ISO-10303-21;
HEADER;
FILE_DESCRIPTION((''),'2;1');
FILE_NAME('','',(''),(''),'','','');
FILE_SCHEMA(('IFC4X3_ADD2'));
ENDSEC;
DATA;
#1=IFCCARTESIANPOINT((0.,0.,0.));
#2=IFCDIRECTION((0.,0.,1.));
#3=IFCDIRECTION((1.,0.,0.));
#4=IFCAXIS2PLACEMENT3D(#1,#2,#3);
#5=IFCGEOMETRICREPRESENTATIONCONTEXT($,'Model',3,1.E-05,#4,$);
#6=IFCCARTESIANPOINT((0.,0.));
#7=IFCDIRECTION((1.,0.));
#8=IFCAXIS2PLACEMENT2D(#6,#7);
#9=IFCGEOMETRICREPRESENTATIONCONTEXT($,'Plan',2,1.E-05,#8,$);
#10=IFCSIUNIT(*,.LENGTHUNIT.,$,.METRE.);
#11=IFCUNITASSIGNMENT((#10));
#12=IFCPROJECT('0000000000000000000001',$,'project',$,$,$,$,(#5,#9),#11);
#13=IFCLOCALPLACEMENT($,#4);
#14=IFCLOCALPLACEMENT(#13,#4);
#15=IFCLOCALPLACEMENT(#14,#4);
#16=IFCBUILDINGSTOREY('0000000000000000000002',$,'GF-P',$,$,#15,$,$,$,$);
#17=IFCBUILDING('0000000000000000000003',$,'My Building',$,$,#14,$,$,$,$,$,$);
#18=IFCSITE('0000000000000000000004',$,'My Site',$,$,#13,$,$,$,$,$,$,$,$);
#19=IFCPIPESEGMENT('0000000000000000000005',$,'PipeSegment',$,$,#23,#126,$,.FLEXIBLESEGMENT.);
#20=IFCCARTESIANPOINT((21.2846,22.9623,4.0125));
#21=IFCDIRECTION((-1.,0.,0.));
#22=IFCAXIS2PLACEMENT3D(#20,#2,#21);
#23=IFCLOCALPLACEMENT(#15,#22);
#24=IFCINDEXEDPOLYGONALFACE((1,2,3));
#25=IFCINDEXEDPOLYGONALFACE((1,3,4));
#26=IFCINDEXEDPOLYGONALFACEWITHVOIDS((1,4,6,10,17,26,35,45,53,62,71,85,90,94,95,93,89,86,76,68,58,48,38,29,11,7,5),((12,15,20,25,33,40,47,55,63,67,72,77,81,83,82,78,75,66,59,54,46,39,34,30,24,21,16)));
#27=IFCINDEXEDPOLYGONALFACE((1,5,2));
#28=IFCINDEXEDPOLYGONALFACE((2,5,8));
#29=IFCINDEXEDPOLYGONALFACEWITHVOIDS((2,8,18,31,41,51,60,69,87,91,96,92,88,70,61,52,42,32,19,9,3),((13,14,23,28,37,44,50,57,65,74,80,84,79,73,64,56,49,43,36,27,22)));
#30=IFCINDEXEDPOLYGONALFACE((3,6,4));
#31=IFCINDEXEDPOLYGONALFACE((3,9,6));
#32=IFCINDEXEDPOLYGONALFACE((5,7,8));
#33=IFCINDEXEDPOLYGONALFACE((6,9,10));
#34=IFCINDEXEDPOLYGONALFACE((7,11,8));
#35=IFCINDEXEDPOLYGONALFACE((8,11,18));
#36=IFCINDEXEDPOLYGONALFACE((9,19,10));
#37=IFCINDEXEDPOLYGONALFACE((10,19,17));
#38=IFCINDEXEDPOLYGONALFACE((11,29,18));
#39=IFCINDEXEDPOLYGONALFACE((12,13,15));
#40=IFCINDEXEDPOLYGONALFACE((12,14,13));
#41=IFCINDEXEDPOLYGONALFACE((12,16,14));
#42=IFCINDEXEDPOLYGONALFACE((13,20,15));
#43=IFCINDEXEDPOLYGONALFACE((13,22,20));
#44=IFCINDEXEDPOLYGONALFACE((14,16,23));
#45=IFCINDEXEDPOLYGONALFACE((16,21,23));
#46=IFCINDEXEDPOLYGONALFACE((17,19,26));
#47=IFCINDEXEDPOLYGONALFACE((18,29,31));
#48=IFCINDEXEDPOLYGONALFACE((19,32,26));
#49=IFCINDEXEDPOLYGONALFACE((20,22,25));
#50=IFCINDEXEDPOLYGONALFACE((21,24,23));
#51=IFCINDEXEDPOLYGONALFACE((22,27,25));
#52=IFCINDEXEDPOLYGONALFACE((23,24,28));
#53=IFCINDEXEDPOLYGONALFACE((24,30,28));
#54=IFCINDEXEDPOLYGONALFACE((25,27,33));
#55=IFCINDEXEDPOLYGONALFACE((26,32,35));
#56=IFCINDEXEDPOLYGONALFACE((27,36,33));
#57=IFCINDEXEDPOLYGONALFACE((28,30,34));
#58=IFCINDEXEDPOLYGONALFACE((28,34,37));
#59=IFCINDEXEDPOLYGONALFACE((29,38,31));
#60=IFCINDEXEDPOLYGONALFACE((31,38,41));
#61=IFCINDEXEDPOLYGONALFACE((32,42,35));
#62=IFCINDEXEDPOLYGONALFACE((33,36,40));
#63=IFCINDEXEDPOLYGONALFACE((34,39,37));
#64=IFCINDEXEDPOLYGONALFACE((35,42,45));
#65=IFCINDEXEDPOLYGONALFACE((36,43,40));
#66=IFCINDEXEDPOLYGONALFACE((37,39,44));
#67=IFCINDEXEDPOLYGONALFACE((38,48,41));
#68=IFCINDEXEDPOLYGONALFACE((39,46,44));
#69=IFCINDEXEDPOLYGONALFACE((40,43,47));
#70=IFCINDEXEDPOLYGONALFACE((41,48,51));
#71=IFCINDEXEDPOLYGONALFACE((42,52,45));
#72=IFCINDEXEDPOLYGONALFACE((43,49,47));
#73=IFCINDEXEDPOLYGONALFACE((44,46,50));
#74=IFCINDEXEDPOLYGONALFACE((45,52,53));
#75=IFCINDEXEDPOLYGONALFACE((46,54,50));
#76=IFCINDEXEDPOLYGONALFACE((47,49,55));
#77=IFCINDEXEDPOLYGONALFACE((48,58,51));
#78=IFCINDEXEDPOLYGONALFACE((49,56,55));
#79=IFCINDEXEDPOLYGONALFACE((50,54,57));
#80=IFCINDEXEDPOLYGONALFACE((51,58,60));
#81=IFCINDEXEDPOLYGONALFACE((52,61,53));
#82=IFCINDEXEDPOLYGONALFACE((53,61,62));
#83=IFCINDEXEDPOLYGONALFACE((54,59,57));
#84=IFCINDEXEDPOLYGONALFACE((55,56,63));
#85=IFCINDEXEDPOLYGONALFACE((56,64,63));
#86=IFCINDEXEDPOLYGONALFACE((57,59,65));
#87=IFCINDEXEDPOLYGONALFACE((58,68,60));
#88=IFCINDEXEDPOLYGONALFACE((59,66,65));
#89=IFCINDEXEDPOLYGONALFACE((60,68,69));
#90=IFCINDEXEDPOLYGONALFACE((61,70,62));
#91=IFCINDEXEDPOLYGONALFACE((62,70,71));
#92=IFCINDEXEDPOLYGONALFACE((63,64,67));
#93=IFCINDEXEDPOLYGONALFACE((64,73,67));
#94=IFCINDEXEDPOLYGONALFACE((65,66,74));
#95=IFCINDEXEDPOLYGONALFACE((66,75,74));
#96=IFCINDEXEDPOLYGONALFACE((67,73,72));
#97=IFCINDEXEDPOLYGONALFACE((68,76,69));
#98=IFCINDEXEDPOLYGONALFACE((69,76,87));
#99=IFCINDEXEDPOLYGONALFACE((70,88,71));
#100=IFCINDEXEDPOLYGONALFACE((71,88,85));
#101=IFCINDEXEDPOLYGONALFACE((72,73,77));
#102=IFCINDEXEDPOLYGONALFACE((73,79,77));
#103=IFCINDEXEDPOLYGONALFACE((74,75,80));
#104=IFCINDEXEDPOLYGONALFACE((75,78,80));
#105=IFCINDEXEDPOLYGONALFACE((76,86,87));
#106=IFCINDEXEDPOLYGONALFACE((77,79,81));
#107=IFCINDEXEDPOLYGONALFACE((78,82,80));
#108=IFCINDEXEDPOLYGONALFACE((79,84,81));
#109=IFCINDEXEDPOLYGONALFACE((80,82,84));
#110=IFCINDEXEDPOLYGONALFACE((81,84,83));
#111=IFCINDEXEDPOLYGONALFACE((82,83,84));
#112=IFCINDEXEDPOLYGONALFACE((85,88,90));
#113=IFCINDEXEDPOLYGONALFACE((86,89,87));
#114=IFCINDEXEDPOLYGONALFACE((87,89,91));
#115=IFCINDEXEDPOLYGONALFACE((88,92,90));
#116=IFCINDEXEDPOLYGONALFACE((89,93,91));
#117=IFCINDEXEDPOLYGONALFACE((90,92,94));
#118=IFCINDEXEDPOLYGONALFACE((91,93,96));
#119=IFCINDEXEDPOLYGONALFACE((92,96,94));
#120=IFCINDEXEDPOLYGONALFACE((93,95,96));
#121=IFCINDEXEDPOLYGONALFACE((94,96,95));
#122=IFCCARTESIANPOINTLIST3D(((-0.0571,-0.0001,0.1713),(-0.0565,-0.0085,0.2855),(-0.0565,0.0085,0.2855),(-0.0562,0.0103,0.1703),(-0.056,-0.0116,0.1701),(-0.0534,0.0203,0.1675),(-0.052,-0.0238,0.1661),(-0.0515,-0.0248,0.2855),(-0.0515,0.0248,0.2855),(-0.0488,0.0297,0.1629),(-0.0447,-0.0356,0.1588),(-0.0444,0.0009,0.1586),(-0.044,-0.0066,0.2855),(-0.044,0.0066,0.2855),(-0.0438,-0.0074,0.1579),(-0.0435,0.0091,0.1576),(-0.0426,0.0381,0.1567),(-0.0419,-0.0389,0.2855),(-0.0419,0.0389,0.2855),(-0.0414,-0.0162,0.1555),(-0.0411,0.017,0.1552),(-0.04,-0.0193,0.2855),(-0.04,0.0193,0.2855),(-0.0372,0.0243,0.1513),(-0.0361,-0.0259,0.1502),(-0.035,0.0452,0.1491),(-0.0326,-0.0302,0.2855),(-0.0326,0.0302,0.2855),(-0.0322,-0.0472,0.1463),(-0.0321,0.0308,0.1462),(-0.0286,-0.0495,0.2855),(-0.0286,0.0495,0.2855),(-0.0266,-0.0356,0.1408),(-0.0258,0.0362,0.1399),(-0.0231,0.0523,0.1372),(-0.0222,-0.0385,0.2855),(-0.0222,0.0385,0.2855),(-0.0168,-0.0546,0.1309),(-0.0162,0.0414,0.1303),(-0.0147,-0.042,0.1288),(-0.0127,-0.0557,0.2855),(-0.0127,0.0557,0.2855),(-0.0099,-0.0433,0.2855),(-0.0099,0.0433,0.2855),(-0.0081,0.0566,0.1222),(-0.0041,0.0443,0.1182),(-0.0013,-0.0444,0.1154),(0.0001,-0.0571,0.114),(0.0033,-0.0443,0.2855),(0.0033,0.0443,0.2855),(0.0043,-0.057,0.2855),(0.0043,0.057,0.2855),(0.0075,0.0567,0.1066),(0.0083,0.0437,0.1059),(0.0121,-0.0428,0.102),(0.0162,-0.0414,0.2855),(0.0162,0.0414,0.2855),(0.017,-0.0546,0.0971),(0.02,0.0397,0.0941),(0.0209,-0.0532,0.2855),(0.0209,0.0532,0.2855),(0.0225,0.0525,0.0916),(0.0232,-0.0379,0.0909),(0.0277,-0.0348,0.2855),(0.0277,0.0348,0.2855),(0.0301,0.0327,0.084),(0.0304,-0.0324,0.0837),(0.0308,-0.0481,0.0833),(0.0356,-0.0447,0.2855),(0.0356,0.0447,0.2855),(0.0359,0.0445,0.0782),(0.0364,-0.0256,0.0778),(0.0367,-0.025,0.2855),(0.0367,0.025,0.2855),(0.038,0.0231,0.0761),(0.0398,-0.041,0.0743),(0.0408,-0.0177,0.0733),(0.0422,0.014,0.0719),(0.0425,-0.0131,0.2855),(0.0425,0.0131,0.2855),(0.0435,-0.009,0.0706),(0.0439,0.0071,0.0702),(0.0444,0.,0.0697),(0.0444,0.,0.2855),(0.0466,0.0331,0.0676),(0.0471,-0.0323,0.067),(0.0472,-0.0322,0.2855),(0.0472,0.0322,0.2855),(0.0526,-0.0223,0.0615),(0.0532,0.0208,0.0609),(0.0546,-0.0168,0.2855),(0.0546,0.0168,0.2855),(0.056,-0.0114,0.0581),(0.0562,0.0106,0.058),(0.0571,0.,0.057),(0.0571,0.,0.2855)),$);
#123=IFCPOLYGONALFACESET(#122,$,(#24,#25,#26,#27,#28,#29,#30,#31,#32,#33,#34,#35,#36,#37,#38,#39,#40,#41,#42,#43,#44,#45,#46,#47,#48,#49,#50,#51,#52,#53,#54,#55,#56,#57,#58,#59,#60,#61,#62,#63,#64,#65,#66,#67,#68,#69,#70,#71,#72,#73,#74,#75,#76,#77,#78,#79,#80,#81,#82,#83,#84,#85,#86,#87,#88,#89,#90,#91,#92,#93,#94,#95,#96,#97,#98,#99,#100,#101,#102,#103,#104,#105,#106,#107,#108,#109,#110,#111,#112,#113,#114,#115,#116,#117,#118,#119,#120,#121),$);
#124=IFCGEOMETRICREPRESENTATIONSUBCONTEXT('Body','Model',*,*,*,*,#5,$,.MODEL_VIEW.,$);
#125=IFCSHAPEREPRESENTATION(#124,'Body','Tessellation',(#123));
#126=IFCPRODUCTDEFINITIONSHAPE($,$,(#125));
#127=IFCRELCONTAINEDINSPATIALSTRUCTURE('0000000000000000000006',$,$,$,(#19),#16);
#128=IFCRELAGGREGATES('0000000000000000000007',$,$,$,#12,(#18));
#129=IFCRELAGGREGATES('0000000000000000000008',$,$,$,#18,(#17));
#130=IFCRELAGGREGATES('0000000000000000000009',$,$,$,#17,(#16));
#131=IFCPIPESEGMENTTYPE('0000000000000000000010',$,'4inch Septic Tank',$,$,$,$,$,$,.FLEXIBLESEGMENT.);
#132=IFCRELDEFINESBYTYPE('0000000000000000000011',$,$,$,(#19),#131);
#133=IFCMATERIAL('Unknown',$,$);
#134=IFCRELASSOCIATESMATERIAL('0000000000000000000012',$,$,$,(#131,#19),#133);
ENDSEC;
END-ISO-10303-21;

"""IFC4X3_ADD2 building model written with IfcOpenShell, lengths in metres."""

from ifc_helpers import new_model, si_unit, frame, origin_with_axes, origin_2d_with_axis, place, context, subcontext, project, spatial, hollow_circle, extrude, clip, halfspace, material, material_profile, profile_set, profile_usage, type_object, element, save


model = new_model("IFC4X3_ADD2")

# Units and contexts
model_context = context("Model", 3, precision=1e-05, world=origin_with_axes())
plan_context = context("Plan", 2, precision=1e-05, world=origin_2d_with_axis())
body_context = subcontext(model_context, "Body", "Model", "MODEL_VIEW")
ifc_project = project(units=[si_unit("LENGTHUNIT", "METRE")], contexts=[model_context, plan_context])

# Site, building, storey
site_placement = place(None, origin_with_axes())
site = spatial("IfcSite", under=ifc_project, at=site_placement, Name="My Site")
building_placement = place(site_placement, origin_with_axes())
building = spatial("IfcBuilding", under=site, at=building_placement, Name="My Building")
storey_placement = place(building_placement, origin_with_axes())
storey = spatial("IfcBuildingStorey", under=building, at=storey_placement, Name="GF-P")

# Pipe segment
ifc_material_1 = material(Name="Unknown")
ifc_material_profile_1 = material_profile(ifc_material_1, hollow_circle(Radius=0.0571, WallThickness=0.0127))
ifc_profile_set_1 = profile_set([ifc_material_profile_1], Name="blackwater")
pipe_segment_type_1 = type_object("IfcPipeSegmentType", Name="4inch Septic Tank", PredefinedType="FLEXIBLESEGMENT", material=ifc_profile_set_1)
ifc_profile_usage_1 = profile_usage(ifc_profile_set_1, cardinal=5)
pipe_segment_1_placement = place(storey_placement, frame((21.2846, 22.9623, 4.0125), z_axis=(0.0, 0.0, 1.0), x_axis=(-1.0, 0.0, 0.0)))
element("IfcPipeSegment", 1, at=pipe_segment_1_placement, inside=storey, type_object=pipe_segment_type_1, material=ifc_profile_usage_1, Name="PipeSegment", PredefinedType="FLEXIBLESEGMENT", context=body_context, shape_type="Clipping", body=[
    clip(extrude(hollow_circle(Radius=0.0571, WallThickness=0.0127), origin_with_axes(), (0.0, 0.0, 1.0), 0.2855), halfspace(frame((1.0547, 0.0, -0.9406), z_axis=(-0.707107, 0.0, -0.707107), x_axis=(0.0, 1.0, 0.0)), False)),
])

save(model, "model.ifc")
